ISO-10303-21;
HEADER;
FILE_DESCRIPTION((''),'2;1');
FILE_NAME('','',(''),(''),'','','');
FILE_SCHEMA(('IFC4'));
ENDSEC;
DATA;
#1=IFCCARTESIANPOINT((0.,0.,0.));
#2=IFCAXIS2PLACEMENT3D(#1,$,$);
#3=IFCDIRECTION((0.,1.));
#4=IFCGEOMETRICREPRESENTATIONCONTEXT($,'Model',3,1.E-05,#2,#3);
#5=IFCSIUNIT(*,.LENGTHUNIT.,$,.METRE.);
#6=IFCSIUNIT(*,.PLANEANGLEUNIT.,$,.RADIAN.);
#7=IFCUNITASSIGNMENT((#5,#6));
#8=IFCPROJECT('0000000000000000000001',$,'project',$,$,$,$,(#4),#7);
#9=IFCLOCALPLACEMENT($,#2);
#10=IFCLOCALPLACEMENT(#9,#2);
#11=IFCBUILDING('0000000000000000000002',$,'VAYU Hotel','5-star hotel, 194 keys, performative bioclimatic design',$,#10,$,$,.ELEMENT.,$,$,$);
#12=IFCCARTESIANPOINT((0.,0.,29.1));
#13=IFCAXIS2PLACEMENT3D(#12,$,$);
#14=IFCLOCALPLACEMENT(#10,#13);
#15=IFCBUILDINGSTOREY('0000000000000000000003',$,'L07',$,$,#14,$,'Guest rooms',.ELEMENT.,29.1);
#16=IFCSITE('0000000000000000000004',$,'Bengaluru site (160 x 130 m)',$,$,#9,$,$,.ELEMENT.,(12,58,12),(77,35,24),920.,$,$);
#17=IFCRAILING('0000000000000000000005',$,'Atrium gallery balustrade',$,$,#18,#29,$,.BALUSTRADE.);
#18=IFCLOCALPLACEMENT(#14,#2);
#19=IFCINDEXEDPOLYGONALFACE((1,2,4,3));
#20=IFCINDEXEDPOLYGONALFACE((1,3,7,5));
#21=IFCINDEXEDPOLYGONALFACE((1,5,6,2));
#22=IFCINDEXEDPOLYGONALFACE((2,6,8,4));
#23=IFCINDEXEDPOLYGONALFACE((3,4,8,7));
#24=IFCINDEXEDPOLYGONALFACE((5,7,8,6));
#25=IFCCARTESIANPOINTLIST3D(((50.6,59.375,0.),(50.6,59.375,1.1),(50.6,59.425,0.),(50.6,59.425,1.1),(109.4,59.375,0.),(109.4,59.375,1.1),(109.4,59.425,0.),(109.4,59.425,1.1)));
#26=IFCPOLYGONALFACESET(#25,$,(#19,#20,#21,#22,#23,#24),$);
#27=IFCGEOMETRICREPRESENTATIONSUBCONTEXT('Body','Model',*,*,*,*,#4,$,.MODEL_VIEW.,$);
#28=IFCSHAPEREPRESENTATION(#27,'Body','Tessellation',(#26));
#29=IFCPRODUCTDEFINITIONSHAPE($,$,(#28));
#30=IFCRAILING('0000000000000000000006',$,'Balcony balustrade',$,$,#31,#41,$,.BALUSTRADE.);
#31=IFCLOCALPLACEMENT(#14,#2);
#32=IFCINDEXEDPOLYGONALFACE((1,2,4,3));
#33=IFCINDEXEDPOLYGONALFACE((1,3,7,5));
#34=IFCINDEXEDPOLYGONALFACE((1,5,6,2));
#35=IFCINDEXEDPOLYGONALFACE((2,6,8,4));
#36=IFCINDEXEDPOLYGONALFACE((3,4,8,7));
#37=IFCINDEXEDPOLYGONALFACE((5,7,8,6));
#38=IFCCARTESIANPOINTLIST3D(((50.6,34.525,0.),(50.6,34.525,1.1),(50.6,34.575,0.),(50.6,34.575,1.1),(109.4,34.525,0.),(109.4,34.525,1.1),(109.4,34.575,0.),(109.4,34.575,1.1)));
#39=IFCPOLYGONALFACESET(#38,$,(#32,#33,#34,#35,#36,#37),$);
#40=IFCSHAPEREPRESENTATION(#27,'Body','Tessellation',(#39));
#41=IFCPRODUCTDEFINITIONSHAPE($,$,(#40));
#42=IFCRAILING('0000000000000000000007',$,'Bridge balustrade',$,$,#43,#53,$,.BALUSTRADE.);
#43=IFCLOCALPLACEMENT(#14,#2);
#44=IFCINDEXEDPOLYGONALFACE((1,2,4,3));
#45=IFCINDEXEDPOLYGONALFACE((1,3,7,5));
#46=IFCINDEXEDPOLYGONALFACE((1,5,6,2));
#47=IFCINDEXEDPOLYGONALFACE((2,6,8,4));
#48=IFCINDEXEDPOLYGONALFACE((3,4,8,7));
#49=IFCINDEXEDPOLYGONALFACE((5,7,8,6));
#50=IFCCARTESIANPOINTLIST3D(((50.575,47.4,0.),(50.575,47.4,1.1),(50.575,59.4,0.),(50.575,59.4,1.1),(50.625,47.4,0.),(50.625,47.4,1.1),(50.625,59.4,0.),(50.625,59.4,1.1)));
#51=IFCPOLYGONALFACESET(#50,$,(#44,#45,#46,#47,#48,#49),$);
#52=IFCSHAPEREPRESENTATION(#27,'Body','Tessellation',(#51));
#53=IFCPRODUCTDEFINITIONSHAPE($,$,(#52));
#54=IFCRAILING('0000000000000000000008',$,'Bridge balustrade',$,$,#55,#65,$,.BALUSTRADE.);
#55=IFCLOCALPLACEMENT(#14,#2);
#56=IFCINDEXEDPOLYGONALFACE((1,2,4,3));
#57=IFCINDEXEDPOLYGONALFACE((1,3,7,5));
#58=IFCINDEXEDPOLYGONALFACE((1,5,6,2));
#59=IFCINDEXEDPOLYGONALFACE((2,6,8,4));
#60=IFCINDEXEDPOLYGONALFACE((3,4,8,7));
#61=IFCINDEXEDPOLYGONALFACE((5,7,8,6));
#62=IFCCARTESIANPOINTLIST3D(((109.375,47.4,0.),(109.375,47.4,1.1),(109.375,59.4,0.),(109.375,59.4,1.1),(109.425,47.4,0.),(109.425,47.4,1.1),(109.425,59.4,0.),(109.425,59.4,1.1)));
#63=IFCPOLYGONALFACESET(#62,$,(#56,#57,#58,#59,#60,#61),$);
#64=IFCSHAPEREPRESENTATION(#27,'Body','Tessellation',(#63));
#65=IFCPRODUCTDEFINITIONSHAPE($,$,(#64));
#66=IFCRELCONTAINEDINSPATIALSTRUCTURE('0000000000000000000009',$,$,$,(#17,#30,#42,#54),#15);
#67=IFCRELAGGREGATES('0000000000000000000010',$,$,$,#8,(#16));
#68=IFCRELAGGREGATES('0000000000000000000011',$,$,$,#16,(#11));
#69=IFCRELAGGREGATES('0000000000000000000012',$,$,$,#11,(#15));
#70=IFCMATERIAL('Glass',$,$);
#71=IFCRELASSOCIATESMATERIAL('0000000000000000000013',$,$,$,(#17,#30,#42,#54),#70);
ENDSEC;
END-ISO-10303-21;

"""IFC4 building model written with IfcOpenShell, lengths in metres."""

from ifc_helpers import new_model, si_unit, direction, frame, origin, place, context, subcontext, project, spatial, polyline, outline, extrude, material, element, save


model = new_model("IFC4")

# Units and contexts
model_context = context("Model", 3, precision=1e-05, world=origin(), true_north=direction((0.0, 1.0)))
body_context = subcontext(model_context, "Body", "Model", "MODEL_VIEW")
ifc_project = project(units=[si_unit("LENGTHUNIT", "METRE"), si_unit("PLANEANGLEUNIT", "RADIAN")], contexts=[model_context])

# Site, building, storey
site_placement = place(None, origin())
site = spatial("IfcSite", under=ifc_project, at=site_placement, Name="Bengaluru site (160 x 130 m)", CompositionType="ELEMENT", RefLatitude=(12, 58, 12), RefLongitude=(77, 35, 24), RefElevation=920.0)
building_placement = place(site_placement, origin())
building = spatial("IfcBuilding", under=site, at=building_placement, Name="VAYU Hotel", Description="5-star hotel, 194 keys, performative bioclimatic design", CompositionType="ELEMENT")
storey_placement = place(building_placement, frame((0.0, 0.0, 29.1)))
storey = spatial("IfcBuildingStorey", under=building, at=storey_placement, Name="L07", LongName="Guest rooms", CompositionType="ELEMENT", Elevation=29.1)

# Railings
ifc_material_1 = material(Name="Glass")
railing_1_placement = place(storey_placement, origin())
element("IfcRailing", 1, at=railing_1_placement, inside=storey, material=ifc_material_1, Name="Atrium gallery balustrade", PredefinedType="BALUSTRADE", context=body_context, shape_type="SweptSolid", body=[
    extrude(outline(polyline([(50.6, 59.425), (109.4, 59.425), (109.4, 59.375), (50.6, 59.375), (50.6, 59.425)])), origin(), (0.0, 0.0, 1.0), 1.1),
])
railing_2_placement = place(storey_placement, origin())
element("IfcRailing", 2, at=railing_2_placement, inside=storey, material=ifc_material_1, Name="Balcony balustrade", PredefinedType="BALUSTRADE", context=body_context, shape_type="SweptSolid", body=[
    extrude(outline(polyline([(50.6, 34.575), (109.4, 34.575), (109.4, 34.525), (50.6, 34.525), (50.6, 34.575)])), origin(), (0.0, 0.0, 1.0), 1.1),
])
railing_3_placement = place(storey_placement, origin())
element("IfcRailing", 3, at=railing_3_placement, inside=storey, material=ifc_material_1, Name="Bridge balustrade", PredefinedType="BALUSTRADE", context=body_context, shape_type="SweptSolid", body=[
    extrude(outline(polyline([(50.575, 47.4), (50.575, 59.4), (50.625, 59.4), (50.625, 47.4), (50.575, 47.4)])), origin(), (0.0, 0.0, 1.0), 1.1),
])
railing_4_placement = place(storey_placement, origin())
element("IfcRailing", 4, at=railing_4_placement, inside=storey, material=ifc_material_1, Name="Bridge balustrade", PredefinedType="BALUSTRADE", context=body_context, shape_type="SweptSolid", body=[
    extrude(outline(polyline([(109.375, 47.4), (109.375, 59.4), (109.425, 59.4), (109.425, 47.4), (109.375, 47.4)])), origin(), (0.0, 0.0, 1.0), 1.1),
])

save(model, "model.ifc")
